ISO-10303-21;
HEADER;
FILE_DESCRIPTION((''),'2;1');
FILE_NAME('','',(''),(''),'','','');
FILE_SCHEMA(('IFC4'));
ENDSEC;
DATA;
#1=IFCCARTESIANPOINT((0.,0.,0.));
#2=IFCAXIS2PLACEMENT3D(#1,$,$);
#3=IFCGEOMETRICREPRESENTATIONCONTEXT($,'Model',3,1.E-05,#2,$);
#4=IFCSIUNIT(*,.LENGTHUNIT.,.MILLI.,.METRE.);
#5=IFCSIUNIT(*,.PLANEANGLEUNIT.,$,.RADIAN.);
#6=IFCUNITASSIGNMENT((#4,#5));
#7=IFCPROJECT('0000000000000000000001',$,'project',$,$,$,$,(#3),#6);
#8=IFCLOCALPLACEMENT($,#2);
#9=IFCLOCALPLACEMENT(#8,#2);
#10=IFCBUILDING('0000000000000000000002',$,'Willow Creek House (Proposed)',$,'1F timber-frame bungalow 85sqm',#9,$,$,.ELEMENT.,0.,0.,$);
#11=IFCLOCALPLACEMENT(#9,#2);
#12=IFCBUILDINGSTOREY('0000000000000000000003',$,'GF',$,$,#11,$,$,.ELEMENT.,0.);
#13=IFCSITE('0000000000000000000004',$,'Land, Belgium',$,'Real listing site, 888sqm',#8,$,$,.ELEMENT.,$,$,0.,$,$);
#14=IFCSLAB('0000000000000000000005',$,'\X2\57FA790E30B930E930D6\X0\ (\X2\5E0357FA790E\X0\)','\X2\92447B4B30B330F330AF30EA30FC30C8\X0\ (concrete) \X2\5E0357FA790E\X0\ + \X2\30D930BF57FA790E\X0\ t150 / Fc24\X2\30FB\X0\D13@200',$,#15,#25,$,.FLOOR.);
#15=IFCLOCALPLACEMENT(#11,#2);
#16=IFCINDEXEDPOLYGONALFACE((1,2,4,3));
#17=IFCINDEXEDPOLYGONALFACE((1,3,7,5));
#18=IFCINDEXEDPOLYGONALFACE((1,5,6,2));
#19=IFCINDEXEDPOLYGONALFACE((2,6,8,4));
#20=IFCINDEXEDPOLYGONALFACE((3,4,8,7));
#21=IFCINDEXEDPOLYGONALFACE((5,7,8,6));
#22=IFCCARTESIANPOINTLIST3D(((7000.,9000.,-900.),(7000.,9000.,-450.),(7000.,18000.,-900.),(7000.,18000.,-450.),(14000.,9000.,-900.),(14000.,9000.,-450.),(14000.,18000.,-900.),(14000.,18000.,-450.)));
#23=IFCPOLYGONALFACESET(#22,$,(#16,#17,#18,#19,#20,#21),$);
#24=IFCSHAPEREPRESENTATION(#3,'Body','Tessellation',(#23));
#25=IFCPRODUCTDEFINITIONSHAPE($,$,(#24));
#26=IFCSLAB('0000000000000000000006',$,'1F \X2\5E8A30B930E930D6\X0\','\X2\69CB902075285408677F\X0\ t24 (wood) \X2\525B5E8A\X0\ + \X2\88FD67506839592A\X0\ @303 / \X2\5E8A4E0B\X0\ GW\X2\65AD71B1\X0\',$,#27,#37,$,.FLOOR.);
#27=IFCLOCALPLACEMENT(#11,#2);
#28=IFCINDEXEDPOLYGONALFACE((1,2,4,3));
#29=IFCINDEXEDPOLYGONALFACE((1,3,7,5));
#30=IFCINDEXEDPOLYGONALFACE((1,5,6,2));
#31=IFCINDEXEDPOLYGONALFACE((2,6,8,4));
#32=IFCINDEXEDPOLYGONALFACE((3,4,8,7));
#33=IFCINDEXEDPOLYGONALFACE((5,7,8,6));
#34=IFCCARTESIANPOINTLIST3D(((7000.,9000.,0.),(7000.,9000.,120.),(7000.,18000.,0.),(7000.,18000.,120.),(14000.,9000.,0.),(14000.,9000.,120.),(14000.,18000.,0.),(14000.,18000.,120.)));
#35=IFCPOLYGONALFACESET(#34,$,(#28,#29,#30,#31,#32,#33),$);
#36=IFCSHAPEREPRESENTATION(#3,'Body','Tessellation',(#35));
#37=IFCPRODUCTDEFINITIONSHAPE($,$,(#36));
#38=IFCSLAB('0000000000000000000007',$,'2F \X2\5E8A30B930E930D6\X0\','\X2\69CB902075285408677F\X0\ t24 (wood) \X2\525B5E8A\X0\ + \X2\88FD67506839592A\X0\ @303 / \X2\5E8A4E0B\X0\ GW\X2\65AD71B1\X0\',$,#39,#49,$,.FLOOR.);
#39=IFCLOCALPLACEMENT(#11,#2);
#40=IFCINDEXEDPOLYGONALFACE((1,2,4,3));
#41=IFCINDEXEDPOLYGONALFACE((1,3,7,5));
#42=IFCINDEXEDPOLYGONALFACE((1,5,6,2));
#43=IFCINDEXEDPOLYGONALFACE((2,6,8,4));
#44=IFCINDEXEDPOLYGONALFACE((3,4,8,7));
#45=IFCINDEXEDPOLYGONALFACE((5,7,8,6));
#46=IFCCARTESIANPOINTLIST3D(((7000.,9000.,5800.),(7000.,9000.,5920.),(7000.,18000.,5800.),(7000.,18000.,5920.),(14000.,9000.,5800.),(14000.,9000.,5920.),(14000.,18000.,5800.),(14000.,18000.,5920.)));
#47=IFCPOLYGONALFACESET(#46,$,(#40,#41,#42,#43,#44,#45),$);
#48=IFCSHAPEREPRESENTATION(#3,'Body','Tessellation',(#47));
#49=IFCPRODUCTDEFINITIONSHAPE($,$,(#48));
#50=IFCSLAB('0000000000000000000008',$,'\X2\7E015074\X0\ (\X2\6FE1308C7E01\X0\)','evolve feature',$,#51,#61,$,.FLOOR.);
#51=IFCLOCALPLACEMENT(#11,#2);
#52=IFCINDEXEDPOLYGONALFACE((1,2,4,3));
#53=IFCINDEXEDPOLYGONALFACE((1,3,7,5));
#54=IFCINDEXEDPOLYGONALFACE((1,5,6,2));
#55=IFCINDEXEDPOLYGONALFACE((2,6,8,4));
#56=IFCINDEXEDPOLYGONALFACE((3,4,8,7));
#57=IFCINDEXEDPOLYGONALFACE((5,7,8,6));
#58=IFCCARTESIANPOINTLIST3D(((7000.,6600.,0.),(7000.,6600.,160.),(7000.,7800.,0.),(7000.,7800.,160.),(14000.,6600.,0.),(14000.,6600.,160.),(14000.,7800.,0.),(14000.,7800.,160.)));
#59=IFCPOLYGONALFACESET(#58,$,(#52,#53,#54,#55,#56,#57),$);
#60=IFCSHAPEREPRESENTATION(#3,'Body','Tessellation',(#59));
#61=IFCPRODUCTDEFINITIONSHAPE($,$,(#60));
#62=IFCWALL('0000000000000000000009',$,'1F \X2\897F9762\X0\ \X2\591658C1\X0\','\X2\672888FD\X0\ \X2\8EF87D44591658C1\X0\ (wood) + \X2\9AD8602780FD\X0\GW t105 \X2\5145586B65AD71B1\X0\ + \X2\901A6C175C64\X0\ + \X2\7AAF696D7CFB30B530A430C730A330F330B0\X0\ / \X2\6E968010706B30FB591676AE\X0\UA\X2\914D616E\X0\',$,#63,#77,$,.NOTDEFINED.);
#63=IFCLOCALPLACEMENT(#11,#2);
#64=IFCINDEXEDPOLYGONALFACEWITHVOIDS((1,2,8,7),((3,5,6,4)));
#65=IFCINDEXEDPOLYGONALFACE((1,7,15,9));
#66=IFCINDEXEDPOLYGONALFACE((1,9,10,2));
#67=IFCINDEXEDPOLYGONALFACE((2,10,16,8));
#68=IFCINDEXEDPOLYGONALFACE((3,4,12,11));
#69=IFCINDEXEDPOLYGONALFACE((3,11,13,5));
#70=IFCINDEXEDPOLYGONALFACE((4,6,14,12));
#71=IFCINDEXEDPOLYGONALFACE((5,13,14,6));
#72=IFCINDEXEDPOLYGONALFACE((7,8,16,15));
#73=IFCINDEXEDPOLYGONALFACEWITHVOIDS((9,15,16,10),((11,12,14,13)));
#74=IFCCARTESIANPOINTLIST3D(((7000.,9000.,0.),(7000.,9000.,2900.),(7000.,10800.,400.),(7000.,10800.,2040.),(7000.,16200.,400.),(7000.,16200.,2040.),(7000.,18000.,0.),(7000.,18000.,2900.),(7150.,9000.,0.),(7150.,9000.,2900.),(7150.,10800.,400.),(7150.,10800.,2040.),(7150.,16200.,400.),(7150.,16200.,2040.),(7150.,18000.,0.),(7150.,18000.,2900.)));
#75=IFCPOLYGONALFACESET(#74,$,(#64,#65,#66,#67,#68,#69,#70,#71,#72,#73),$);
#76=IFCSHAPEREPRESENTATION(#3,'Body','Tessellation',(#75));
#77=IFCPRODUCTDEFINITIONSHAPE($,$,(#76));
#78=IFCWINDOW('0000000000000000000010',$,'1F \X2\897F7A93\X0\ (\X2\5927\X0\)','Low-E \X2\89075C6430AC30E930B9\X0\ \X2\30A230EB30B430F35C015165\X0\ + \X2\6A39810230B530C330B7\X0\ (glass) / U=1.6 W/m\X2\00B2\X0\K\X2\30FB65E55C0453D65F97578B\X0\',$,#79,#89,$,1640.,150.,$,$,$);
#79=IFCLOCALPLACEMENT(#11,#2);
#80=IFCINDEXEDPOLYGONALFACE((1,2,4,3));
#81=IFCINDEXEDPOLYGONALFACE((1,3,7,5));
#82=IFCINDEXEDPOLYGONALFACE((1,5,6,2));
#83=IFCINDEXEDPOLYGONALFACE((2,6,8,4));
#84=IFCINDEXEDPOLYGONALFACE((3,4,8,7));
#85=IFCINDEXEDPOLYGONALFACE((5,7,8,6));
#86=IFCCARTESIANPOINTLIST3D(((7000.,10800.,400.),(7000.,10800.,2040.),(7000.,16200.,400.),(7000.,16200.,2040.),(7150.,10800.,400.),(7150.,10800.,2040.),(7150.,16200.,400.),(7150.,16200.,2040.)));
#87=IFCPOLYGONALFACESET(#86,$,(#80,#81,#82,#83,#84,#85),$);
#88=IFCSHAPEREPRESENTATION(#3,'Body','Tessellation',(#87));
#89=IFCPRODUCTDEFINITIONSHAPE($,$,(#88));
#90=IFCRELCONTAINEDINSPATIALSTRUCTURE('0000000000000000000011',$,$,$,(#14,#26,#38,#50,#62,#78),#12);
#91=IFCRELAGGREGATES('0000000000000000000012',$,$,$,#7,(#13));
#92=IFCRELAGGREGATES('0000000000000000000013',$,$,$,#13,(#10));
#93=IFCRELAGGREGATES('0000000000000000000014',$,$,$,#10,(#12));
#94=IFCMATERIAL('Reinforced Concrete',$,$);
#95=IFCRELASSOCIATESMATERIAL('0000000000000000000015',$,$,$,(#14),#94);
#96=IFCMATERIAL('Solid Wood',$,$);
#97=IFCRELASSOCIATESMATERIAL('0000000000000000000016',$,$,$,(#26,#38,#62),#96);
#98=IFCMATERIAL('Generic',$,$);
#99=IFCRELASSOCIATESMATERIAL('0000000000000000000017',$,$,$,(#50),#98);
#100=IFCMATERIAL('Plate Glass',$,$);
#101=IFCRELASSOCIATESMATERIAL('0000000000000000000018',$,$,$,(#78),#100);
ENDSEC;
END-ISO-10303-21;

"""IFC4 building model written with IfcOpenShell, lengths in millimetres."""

from ifc_helpers import new_model, si_unit, frame, frame_2d, origin, place, context, project, spatial, rectangle, extrude, material, element, fill, save


model = new_model("IFC4")

# Units and contexts
model_context = context("Model", 3, precision=1e-05, world=origin())
ifc_project = project(units=[si_unit("LENGTHUNIT", "METRE", prefix="MILLI"), si_unit("PLANEANGLEUNIT", "RADIAN")], contexts=[model_context])

# Site, building, storey
site_placement = place(None, origin())
site = spatial("IfcSite", under=ifc_project, at=site_placement, Name="Land, Belgium", ObjectType="Real listing site, 888sqm", CompositionType="ELEMENT", RefElevation=0.0)
building_placement = place(site_placement, origin())
building = spatial("IfcBuilding", under=site, at=building_placement, Name="Willow Creek House (Proposed)", ObjectType="1F timber-frame bungalow 85sqm", CompositionType="ELEMENT", ElevationOfRefHeight=0.0, ElevationOfTerrain=0.0)
storey_placement = place(building_placement, origin())
storey = spatial("IfcBuildingStorey", under=building, at=storey_placement, Name="GF", CompositionType="ELEMENT", Elevation=0.0)

# Slabs
ifc_material_1 = material(Name="Reinforced Concrete")
slab_1_placement = place(storey_placement, frame((3500.0, 4500.0, -450.0)))
element("IfcSlab", 1, at=slab_1_placement, inside=storey, material=ifc_material_1, Name="基礎スラブ (布基礎)", Description="鉄筋コンクリート (concrete) 布基礎 + ベタ基礎 t150 / Fc24・D13@200", PredefinedType="FLOOR", context=model_context, shape_type="SweptSolid", body=[
    extrude(rectangle(XDim=7000.0, YDim=9000.0, at=frame_2d((3500.0, 4500.0))), frame((3500.0, 4500.0, -450.0)), (0.0, 0.0, 1.0), 450.0),
])
ifc_material_2 = material(Name="Solid Wood")
slab_2_placement = place(storey_placement, frame((3500.0, 4500.0, 0.0)))
element("IfcSlab", 2, at=slab_2_placement, inside=storey, material=ifc_material_2, Name="1F 床スラブ", Description="構造用合板 t24 (wood) 剛床 + 製材根太 @303 / 床下 GW断熱", PredefinedType="FLOOR", context=model_context, shape_type="SweptSolid", body=[
    extrude(rectangle(XDim=7000.0, YDim=9000.0, at=frame_2d((3500.0, 4500.0))), frame((3500.0, 4500.0, 0.0)), (0.0, 0.0, 1.0), 120.0),
])
slab_3_placement = place(storey_placement, frame((3500.0, 4500.0, 2900.0)))
element("IfcSlab", 3, at=slab_3_placement, inside=storey, material=ifc_material_2, Name="2F 床スラブ", Description="構造用合板 t24 (wood) 剛床 + 製材根太 @303 / 床下 GW断熱", PredefinedType="FLOOR", context=model_context, shape_type="SweptSolid", body=[
    extrude(rectangle(XDim=7000.0, YDim=9000.0, at=frame_2d((3500.0, 4500.0))), frame((3500.0, 4500.0, 2900.0)), (0.0, 0.0, 1.0), 120.0),
])
ifc_material_3 = material(Name="Generic")
slab_4_placement = place(storey_placement, frame((3500.0, 3300.0, 0.0)))
element("IfcSlab", 4, at=slab_4_placement, inside=storey, material=ifc_material_3, Name="縁側 (濡れ縁)", Description="evolve feature", PredefinedType="FLOOR", context=model_context, shape_type="SweptSolid", body=[
    extrude(rectangle(XDim=7000.0, YDim=1200.0, at=frame_2d((3500.0, 600.0))), frame((3500.0, 3300.0, 0.0)), (0.0, 0.0, 1.0), 160.0),
])

# Shared definitions
ifc_material_4 = material(Name="Plate Glass")

# Wall, opening, window
wall_1_placement = place(storey_placement, frame((3500.0, 4500.0, 0.0)))
wall_1 = element("IfcWall", 5, at=wall_1_placement, inside=storey, material=ifc_material_2, Name="1F 西面 外壁", Description="木製 軸組外壁 (wood) + 高性能GW t105 充填断熱 + 通気層 + 窯業系サイディング / 準耐火・外皮UA配慮", PredefinedType="NOTDEFINED", context=model_context, shape_type="SweptSolid", body=[
    extrude(rectangle(XDim=150.0, YDim=9000.0, at=frame_2d((75.0, 4500.0))), frame((3500.0, 4500.0, 0.0)), (0.0, 0.0, 1.0), 2900.0),
])
opening_1_placement = place(storey_placement, frame((3500.0, 5400.0, 200.0)))
opening_1 = element("IfcOpeningElement", 6, at=opening_1_placement, cuts=wall_1, PredefinedType="NOTDEFINED", context=model_context, shape_type="SweptSolid", body=[
    extrude(rectangle(XDim=150.0, YDim=5400.0, at=frame_2d((75.0, 2700.0))), frame((3500.0, 5400.0, 200.0)), (0.0, 0.0, 1.0), 1640.0),
])
window_1_placement = place(storey_placement, frame((3500.0, 5400.0, 200.0)))
window_1 = element("IfcWindow", 7, at=window_1_placement, inside=storey, material=ifc_material_4, Name="1F 西窓 (大)", Description="Low-E 複層ガラス アルゴン封入 + 樹脂サッシ (glass) / U=1.6 W/m²K・日射取得型", OverallHeight=1640.0, OverallWidth=150.0, context=model_context, shape_type="SweptSolid", body=[
    extrude(rectangle(XDim=150.0, YDim=5400.0, at=frame_2d((75.0, 2700.0))), frame((3500.0, 5400.0, 200.0)), (0.0, 0.0, 1.0), 1640.0),
])
fill(opening_1, window_1)

save(model, "model.ifc")
